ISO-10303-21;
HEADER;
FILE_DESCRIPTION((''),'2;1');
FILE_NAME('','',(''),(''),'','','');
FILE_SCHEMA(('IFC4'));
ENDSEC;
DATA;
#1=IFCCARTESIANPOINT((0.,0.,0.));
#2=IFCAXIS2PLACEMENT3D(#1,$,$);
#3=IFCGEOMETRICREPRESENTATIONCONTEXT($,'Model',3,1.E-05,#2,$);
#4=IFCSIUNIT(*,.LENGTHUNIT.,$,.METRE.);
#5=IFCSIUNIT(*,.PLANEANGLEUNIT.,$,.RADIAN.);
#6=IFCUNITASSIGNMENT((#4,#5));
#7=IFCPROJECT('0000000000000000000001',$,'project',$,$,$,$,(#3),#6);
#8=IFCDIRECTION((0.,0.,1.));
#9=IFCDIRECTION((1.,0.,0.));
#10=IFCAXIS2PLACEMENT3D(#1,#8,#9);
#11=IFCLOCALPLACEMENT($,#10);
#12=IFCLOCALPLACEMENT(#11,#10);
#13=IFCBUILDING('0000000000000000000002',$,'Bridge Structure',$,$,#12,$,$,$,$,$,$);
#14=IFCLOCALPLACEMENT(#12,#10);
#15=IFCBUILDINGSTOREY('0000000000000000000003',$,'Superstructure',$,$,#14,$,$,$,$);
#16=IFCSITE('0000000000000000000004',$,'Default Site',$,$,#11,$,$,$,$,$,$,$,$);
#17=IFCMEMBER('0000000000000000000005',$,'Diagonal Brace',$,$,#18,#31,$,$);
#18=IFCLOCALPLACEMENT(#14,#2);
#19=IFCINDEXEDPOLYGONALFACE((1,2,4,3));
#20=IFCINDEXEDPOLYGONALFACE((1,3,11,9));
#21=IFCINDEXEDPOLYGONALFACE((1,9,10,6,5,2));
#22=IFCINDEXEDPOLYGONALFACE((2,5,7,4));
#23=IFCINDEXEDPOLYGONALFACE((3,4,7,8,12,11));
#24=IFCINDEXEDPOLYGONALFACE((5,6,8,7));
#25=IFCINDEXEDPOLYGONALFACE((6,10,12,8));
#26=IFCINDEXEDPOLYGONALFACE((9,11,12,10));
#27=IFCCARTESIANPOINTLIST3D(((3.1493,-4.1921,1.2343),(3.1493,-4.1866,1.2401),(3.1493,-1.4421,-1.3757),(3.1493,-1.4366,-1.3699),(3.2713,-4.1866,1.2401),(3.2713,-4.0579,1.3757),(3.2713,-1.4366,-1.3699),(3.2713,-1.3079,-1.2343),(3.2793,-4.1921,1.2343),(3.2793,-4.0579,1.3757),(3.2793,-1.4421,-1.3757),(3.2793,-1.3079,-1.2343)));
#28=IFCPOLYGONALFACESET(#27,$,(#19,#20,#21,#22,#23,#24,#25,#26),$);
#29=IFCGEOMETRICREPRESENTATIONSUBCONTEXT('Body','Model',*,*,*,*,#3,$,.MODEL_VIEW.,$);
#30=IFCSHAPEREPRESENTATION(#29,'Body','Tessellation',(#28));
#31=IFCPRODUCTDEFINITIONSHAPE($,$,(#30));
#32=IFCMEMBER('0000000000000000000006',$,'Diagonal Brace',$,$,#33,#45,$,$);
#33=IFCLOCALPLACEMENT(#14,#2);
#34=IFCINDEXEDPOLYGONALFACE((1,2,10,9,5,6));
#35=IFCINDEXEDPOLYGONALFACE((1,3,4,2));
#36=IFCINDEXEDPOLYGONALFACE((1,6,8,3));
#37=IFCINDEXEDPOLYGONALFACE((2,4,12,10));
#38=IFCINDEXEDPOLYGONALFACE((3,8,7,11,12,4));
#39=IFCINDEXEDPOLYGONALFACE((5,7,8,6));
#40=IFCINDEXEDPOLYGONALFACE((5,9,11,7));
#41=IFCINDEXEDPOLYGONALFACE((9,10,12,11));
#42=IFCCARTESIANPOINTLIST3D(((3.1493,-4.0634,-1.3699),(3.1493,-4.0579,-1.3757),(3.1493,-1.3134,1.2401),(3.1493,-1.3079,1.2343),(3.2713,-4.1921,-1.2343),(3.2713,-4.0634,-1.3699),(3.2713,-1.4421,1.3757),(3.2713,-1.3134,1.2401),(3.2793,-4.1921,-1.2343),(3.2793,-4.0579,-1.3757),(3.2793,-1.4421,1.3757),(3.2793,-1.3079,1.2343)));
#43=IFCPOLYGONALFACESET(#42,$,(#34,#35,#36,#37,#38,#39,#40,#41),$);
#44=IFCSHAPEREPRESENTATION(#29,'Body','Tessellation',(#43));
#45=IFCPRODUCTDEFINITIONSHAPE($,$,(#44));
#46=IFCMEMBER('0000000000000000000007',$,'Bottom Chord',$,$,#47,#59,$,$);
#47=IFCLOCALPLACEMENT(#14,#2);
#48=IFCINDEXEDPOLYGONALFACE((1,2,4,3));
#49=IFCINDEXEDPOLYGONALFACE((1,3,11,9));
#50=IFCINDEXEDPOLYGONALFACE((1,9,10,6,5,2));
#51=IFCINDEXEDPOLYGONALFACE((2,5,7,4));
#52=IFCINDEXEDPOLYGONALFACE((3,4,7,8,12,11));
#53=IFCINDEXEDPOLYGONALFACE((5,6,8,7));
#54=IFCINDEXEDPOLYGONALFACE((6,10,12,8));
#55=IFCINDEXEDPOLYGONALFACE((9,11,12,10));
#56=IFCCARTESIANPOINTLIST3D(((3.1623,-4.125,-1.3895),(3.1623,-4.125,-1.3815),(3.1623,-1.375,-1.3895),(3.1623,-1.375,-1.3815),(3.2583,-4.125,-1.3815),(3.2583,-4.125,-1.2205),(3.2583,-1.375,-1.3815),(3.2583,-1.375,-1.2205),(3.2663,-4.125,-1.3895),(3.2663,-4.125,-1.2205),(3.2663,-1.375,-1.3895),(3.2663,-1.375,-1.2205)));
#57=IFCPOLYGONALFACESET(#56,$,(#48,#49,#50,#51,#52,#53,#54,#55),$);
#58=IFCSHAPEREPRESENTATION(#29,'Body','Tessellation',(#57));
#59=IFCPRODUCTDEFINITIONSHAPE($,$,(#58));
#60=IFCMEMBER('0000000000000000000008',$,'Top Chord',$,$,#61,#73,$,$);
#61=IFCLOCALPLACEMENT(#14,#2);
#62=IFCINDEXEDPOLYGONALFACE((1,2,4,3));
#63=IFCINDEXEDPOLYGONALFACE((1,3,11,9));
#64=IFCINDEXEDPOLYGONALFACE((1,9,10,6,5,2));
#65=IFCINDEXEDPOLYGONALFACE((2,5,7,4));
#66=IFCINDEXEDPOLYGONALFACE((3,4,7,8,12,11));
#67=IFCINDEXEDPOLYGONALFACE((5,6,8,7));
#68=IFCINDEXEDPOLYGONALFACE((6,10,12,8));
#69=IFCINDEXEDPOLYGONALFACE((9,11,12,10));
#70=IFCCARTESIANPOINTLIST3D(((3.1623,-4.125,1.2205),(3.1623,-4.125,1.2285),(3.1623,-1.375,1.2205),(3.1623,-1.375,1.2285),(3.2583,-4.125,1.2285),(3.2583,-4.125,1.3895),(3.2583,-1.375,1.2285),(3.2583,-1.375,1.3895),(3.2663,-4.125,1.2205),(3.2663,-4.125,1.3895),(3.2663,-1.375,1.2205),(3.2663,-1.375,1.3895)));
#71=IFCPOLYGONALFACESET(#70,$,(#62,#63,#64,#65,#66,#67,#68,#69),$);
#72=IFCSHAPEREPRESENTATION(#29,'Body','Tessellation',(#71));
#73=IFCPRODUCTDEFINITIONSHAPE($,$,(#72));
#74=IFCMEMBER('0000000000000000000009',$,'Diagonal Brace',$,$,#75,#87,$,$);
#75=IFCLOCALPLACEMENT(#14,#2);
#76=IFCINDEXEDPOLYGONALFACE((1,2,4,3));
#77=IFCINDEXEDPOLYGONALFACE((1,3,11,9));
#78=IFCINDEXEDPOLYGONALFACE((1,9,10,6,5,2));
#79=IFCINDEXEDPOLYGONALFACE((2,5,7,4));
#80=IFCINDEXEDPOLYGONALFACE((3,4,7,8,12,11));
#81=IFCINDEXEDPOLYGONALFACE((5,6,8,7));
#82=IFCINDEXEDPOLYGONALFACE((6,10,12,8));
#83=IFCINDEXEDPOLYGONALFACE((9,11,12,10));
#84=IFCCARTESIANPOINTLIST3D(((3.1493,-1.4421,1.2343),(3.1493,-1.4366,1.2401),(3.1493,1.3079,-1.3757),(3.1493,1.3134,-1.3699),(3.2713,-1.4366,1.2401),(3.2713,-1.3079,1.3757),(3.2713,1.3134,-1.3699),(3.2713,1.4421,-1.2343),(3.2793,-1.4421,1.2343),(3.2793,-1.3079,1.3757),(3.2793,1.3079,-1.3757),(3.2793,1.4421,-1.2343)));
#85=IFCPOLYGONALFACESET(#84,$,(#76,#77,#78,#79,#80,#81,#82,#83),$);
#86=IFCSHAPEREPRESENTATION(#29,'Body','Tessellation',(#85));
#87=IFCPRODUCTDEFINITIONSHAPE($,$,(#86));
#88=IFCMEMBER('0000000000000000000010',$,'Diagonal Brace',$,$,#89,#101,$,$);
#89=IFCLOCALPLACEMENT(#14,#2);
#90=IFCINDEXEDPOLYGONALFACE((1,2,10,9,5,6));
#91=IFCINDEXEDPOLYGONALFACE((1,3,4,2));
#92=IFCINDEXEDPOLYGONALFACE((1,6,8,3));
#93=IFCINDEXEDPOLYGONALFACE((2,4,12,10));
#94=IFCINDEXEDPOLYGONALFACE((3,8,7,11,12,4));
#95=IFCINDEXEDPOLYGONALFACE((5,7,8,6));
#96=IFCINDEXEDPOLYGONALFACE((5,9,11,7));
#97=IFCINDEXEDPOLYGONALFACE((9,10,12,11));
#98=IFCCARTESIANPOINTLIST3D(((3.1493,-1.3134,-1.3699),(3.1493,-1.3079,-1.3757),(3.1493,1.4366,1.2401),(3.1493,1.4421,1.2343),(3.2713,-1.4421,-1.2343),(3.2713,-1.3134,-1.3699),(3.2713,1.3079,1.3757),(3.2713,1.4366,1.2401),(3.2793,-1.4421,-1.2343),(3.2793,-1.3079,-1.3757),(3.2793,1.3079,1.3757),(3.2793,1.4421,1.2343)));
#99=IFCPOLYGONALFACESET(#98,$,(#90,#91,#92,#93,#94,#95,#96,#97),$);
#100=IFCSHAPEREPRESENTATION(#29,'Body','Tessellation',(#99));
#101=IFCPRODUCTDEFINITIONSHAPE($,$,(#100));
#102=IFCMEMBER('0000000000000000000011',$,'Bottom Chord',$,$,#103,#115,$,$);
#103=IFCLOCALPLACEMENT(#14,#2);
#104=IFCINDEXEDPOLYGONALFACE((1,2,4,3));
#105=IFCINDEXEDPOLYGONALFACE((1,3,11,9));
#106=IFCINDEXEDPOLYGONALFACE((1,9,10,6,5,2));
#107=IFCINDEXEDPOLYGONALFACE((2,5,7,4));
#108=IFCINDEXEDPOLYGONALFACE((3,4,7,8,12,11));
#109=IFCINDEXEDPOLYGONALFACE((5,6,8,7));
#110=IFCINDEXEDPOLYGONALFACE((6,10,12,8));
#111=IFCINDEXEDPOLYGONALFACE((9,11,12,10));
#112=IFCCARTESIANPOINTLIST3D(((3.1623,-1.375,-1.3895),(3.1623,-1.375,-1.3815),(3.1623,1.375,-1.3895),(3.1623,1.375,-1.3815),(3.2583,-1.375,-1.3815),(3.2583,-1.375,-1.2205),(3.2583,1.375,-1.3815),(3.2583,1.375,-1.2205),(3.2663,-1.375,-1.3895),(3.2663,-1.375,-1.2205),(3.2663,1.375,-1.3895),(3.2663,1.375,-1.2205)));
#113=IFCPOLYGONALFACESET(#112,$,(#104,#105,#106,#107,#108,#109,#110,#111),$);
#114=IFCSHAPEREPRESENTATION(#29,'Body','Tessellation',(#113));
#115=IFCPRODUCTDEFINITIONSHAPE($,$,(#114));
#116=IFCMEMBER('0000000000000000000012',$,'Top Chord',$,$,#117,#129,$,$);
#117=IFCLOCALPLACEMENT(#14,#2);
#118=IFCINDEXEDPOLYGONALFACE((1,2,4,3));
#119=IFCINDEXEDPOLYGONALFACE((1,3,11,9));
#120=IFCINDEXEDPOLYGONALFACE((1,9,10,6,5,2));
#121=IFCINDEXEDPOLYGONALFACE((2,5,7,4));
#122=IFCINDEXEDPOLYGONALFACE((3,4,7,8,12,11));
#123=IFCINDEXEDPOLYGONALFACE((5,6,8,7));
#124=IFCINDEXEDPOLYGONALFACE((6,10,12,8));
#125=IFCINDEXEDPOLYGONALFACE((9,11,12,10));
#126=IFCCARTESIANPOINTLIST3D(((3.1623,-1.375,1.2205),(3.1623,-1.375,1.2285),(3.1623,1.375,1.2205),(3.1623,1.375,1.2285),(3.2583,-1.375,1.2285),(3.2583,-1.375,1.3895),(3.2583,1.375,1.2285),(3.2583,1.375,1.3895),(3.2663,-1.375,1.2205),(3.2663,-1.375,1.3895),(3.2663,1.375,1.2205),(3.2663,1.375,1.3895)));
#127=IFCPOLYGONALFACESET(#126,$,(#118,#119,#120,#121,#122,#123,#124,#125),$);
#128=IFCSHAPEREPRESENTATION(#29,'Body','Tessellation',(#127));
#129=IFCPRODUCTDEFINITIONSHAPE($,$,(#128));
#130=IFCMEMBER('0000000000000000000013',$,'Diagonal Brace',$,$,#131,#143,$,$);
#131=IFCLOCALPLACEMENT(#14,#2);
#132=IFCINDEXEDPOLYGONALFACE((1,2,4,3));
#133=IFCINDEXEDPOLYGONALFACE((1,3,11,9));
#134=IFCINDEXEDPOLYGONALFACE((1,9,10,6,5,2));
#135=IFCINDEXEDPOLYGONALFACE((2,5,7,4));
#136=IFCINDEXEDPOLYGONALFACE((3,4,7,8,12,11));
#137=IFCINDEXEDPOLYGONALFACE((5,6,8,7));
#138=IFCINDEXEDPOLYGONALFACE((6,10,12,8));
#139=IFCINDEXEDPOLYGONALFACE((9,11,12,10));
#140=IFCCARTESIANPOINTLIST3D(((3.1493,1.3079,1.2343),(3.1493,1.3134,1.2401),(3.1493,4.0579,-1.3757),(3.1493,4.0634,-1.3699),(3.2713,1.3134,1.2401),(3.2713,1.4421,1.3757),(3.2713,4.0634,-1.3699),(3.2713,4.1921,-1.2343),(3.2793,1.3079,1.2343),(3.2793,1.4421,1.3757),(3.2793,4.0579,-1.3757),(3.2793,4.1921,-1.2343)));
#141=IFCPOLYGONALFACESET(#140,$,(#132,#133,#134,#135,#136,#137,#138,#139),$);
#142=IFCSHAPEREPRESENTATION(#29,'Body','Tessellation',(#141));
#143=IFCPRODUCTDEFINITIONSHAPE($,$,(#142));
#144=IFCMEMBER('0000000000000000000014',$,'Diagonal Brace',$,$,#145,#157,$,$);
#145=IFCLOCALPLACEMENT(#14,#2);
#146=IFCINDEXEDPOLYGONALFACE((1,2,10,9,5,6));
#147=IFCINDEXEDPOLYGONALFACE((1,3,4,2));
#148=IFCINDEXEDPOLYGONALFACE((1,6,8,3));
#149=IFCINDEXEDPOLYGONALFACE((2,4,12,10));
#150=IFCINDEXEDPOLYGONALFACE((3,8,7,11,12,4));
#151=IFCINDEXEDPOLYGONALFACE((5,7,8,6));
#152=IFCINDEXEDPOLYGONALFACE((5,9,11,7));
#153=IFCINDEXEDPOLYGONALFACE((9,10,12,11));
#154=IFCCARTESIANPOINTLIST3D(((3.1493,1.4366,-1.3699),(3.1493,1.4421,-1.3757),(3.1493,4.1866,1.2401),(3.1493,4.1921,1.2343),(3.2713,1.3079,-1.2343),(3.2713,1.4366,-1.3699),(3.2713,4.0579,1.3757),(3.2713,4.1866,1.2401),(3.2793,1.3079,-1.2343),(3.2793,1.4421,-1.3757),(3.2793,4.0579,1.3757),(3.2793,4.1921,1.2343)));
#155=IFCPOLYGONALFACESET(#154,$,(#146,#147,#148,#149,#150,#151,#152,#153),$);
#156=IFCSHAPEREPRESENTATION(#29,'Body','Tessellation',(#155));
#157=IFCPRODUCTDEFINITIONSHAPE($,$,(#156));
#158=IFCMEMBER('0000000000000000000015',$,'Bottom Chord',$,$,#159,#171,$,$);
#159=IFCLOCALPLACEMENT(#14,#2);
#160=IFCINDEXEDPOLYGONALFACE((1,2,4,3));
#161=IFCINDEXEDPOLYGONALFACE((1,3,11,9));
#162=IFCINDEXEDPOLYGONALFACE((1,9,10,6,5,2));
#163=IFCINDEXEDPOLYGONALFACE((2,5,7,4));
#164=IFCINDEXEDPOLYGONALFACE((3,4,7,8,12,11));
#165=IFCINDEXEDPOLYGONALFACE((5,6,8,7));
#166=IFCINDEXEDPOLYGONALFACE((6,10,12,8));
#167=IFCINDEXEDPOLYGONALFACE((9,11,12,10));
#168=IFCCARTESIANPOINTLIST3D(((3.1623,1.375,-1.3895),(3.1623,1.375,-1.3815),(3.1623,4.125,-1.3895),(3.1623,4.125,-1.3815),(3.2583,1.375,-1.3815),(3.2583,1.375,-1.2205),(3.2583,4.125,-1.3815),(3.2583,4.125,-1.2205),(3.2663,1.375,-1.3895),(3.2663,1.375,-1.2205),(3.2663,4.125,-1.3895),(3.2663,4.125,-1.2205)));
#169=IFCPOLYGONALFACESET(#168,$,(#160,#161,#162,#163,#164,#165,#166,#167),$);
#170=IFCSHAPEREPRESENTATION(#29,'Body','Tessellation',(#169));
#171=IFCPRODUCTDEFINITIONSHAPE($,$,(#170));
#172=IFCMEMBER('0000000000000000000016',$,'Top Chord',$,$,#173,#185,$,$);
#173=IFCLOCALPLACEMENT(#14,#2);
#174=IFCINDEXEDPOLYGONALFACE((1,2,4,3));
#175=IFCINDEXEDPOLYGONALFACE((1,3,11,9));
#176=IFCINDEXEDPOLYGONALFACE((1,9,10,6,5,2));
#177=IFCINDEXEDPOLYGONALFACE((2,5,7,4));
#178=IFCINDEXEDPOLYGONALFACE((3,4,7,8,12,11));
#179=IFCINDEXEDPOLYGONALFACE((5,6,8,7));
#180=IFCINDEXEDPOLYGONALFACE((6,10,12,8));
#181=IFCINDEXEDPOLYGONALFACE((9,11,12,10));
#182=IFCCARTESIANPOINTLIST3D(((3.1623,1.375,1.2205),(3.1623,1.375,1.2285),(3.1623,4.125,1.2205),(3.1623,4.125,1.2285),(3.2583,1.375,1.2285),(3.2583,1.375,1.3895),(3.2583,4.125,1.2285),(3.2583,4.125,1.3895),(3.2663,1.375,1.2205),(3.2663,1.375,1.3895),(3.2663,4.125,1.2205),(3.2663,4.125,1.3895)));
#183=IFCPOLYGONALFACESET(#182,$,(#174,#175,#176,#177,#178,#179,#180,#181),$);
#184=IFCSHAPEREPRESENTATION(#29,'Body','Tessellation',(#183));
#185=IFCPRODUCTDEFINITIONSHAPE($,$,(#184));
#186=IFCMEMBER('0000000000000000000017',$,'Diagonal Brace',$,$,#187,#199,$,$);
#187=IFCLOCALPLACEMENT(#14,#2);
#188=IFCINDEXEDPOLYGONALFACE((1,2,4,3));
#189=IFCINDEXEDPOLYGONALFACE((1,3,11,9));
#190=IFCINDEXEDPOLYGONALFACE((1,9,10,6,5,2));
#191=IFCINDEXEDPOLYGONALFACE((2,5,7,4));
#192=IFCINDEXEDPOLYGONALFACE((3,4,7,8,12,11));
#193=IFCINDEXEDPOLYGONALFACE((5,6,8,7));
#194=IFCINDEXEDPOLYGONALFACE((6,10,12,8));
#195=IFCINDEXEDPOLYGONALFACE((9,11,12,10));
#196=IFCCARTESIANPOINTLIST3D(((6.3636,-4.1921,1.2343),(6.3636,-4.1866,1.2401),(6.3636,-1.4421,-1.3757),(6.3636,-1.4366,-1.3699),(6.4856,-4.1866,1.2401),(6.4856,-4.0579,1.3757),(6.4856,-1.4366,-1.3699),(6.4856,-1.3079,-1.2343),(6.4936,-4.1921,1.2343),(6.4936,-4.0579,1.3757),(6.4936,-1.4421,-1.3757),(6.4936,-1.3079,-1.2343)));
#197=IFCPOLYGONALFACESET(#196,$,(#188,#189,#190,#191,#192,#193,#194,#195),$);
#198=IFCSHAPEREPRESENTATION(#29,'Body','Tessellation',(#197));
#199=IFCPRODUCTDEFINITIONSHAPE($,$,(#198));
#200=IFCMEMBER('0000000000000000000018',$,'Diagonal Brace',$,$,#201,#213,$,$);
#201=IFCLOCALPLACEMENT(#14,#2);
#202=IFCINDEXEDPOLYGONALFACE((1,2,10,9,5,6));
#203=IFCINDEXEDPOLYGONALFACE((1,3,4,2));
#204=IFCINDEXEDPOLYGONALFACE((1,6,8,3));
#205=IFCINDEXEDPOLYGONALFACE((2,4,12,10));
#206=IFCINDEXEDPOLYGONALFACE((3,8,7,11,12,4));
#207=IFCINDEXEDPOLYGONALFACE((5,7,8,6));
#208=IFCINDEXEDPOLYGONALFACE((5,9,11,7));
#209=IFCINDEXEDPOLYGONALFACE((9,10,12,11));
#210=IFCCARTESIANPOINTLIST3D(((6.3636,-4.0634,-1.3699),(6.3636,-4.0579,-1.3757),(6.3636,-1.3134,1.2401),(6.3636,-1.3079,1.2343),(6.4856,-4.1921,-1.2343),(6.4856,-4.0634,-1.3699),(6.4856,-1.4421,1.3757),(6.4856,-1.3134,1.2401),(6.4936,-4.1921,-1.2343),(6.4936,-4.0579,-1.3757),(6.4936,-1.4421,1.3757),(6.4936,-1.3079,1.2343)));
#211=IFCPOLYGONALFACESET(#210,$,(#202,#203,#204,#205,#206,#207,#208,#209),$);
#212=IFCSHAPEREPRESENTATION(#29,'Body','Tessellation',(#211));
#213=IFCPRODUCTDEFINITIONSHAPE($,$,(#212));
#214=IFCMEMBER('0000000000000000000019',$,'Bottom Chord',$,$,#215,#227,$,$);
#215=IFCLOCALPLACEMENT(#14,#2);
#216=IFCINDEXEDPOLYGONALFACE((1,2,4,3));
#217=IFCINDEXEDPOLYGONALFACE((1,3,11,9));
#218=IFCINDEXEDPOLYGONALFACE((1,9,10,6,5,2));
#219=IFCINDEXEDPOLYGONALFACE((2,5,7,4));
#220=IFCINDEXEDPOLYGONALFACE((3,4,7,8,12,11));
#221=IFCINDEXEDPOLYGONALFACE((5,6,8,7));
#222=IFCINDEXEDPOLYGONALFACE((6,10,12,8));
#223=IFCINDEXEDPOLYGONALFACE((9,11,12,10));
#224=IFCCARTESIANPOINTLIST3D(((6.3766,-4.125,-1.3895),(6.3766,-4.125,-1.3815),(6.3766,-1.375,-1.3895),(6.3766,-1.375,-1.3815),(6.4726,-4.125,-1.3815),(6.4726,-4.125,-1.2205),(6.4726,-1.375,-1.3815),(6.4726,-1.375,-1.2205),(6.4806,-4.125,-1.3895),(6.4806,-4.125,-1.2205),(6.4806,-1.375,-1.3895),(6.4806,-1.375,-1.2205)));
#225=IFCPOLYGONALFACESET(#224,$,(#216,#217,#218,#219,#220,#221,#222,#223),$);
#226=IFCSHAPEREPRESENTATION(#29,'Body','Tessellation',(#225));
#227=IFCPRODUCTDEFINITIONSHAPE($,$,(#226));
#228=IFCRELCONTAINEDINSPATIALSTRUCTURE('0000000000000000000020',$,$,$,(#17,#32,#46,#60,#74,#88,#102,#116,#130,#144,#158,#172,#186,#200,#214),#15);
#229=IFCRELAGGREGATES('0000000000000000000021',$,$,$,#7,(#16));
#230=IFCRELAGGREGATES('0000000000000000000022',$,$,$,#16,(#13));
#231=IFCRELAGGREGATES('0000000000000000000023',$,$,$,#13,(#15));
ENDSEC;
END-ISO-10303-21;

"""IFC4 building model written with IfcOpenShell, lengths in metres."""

from ifc_helpers import new_model, si_unit, frame, origin, origin_with_axes, origin_2d_with_axis, place, context, subcontext, project, spatial, l_section, extrude, element, save


model = new_model("IFC4")

# Units and contexts
model_context = context("Model", 3, precision=1e-05, world=origin())
body_context = subcontext(model_context, "Body", "Model", "MODEL_VIEW")
ifc_project = project(units=[si_unit("LENGTHUNIT", "METRE"), si_unit("PLANEANGLEUNIT", "RADIAN")], contexts=[model_context])

# Site, building, storey
site_placement = place(None, origin_with_axes())
site = spatial("IfcSite", under=ifc_project, at=site_placement, Name="Default Site")
building_placement = place(site_placement, origin_with_axes())
building = spatial("IfcBuilding", under=site, at=building_placement, Name="Bridge Structure")
storey_placement = place(building_placement, origin_with_axes())
storey = spatial("IfcBuildingStorey", under=building, at=storey_placement, Name="Superstructure")

# Members
for number, where, z_axis, x_axis, name in (
    (1, (3.2143, -4.125, 1.305), (0.0, 0.725329, -0.688403), (-1.0, 0.0, 0.0), "Diagonal Brace"),
    (2, (3.2143, -4.125, -1.305), (0.0, 0.725329, 0.688403), (-1.0, 0.0, 0.0), "Diagonal Brace"),
):
    element("IfcMember", number, at=place(storey_placement, frame(where, z_axis=z_axis, x_axis=x_axis)), inside=storey, Name=name, context=body_context, shape_type="SweptSolid", body=[
        extrude(l_section(Depth=0.195, Width=0.13, Thickness=0.008, at=origin_2d_with_axis()), origin_with_axes(), (0.0, 0.0, 1.0), 3.7914),
    ])
for number, where, z_axis, x_axis, name in (
    (3, (3.2143, -4.125, -1.305), (0.0, 1.0, 0.0), (-1.0, 0.0, 0.0), "Bottom Chord"),
    (4, (3.2143, -4.125, 1.305), (0.0, 1.0, 0.0), (-1.0, 0.0, 0.0), "Top Chord"),
):
    element("IfcMember", number, at=place(storey_placement, frame(where, z_axis=z_axis, x_axis=x_axis)), inside=storey, Name=name, context=body_context, shape_type="SweptSolid", body=[
        extrude(l_section(Depth=0.169, Width=0.104, Thickness=0.008, at=origin_2d_with_axis()), origin_with_axes(), (0.0, 0.0, 1.0), 2.75),
    ])
for number, where, z_axis, x_axis, name in (
    (5, (3.2143, -1.375, 1.305), (0.0, 0.725329, -0.688403), (-1.0, 0.0, 0.0), "Diagonal Brace"),
    (6, (3.2143, -1.375, -1.305), (0.0, 0.725329, 0.688403), (-1.0, 0.0, 0.0), "Diagonal Brace"),
):
    element("IfcMember", number, at=place(storey_placement, frame(where, z_axis=z_axis, x_axis=x_axis)), inside=storey, Name=name, context=body_context, shape_type="SweptSolid", body=[
        extrude(l_section(Depth=0.195, Width=0.13, Thickness=0.008, at=origin_2d_with_axis()), origin_with_axes(), (0.0, 0.0, 1.0), 3.7914),
    ])
for number, where, z_axis, x_axis, name in (
    (7, (3.2143, -1.375, -1.305), (0.0, 1.0, 0.0), (-1.0, 0.0, 0.0), "Bottom Chord"),
    (8, (3.2143, -1.375, 1.305), (0.0, 1.0, 0.0), (-1.0, 0.0, 0.0), "Top Chord"),
):
    element("IfcMember", number, at=place(storey_placement, frame(where, z_axis=z_axis, x_axis=x_axis)), inside=storey, Name=name, context=body_context, shape_type="SweptSolid", body=[
        extrude(l_section(Depth=0.169, Width=0.104, Thickness=0.008, at=origin_2d_with_axis()), origin_with_axes(), (0.0, 0.0, 1.0), 2.75),
    ])
for number, where, z_axis, x_axis, name in (
    (9, (3.2143, 1.375, 1.305), (0.0, 0.725329, -0.688403), (-1.0, 0.0, 0.0), "Diagonal Brace"),
    (10, (3.2143, 1.375, -1.305), (0.0, 0.725329, 0.688403), (-1.0, 0.0, 0.0), "Diagonal Brace"),
):
    element("IfcMember", number, at=place(storey_placement, frame(where, z_axis=z_axis, x_axis=x_axis)), inside=storey, Name=name, context=body_context, shape_type="SweptSolid", body=[
        extrude(l_section(Depth=0.195, Width=0.13, Thickness=0.008, at=origin_2d_with_axis()), origin_with_axes(), (0.0, 0.0, 1.0), 3.7914),
    ])
for number, where, z_axis, x_axis, name in (
    (11, (3.2143, 1.375, -1.305), (0.0, 1.0, 0.0), (-1.0, 0.0, 0.0), "Bottom Chord"),
    (12, (3.2143, 1.375, 1.305), (0.0, 1.0, 0.0), (-1.0, 0.0, 0.0), "Top Chord"),
):
    element("IfcMember", number, at=place(storey_placement, frame(where, z_axis=z_axis, x_axis=x_axis)), inside=storey, Name=name, context=body_context, shape_type="SweptSolid", body=[
        extrude(l_section(Depth=0.169, Width=0.104, Thickness=0.008, at=origin_2d_with_axis()), origin_with_axes(), (0.0, 0.0, 1.0), 2.75),
    ])
for number, where, z_axis, x_axis, name in (
    (13, (6.4286, -4.125, 1.305), (0.0, 0.725329, -0.688403), (-1.0, 0.0, 0.0), "Diagonal Brace"),
    (14, (6.4286, -4.125, -1.305), (0.0, 0.725329, 0.688403), (-1.0, 0.0, 0.0), "Diagonal Brace"),
):
    element("IfcMember", number, at=place(storey_placement, frame(where, z_axis=z_axis, x_axis=x_axis)), inside=storey, Name=name, context=body_context, shape_type="SweptSolid", body=[
        extrude(l_section(Depth=0.195, Width=0.13, Thickness=0.008, at=origin_2d_with_axis()), origin_with_axes(), (0.0, 0.0, 1.0), 3.7914),
    ])
for number, where, z_axis, x_axis, name in (
    (15, (6.4286, -4.125, -1.305), (0.0, 1.0, 0.0), (-1.0, 0.0, 0.0), "Bottom Chord"),
):
    element("IfcMember", number, at=place(storey_placement, frame(where, z_axis=z_axis, x_axis=x_axis)), inside=storey, Name=name, context=body_context, shape_type="SweptSolid", body=[
        extrude(l_section(Depth=0.169, Width=0.104, Thickness=0.008, at=origin_2d_with_axis()), origin_with_axes(), (0.0, 0.0, 1.0), 2.75),
    ])

save(model, "model.ifc")
